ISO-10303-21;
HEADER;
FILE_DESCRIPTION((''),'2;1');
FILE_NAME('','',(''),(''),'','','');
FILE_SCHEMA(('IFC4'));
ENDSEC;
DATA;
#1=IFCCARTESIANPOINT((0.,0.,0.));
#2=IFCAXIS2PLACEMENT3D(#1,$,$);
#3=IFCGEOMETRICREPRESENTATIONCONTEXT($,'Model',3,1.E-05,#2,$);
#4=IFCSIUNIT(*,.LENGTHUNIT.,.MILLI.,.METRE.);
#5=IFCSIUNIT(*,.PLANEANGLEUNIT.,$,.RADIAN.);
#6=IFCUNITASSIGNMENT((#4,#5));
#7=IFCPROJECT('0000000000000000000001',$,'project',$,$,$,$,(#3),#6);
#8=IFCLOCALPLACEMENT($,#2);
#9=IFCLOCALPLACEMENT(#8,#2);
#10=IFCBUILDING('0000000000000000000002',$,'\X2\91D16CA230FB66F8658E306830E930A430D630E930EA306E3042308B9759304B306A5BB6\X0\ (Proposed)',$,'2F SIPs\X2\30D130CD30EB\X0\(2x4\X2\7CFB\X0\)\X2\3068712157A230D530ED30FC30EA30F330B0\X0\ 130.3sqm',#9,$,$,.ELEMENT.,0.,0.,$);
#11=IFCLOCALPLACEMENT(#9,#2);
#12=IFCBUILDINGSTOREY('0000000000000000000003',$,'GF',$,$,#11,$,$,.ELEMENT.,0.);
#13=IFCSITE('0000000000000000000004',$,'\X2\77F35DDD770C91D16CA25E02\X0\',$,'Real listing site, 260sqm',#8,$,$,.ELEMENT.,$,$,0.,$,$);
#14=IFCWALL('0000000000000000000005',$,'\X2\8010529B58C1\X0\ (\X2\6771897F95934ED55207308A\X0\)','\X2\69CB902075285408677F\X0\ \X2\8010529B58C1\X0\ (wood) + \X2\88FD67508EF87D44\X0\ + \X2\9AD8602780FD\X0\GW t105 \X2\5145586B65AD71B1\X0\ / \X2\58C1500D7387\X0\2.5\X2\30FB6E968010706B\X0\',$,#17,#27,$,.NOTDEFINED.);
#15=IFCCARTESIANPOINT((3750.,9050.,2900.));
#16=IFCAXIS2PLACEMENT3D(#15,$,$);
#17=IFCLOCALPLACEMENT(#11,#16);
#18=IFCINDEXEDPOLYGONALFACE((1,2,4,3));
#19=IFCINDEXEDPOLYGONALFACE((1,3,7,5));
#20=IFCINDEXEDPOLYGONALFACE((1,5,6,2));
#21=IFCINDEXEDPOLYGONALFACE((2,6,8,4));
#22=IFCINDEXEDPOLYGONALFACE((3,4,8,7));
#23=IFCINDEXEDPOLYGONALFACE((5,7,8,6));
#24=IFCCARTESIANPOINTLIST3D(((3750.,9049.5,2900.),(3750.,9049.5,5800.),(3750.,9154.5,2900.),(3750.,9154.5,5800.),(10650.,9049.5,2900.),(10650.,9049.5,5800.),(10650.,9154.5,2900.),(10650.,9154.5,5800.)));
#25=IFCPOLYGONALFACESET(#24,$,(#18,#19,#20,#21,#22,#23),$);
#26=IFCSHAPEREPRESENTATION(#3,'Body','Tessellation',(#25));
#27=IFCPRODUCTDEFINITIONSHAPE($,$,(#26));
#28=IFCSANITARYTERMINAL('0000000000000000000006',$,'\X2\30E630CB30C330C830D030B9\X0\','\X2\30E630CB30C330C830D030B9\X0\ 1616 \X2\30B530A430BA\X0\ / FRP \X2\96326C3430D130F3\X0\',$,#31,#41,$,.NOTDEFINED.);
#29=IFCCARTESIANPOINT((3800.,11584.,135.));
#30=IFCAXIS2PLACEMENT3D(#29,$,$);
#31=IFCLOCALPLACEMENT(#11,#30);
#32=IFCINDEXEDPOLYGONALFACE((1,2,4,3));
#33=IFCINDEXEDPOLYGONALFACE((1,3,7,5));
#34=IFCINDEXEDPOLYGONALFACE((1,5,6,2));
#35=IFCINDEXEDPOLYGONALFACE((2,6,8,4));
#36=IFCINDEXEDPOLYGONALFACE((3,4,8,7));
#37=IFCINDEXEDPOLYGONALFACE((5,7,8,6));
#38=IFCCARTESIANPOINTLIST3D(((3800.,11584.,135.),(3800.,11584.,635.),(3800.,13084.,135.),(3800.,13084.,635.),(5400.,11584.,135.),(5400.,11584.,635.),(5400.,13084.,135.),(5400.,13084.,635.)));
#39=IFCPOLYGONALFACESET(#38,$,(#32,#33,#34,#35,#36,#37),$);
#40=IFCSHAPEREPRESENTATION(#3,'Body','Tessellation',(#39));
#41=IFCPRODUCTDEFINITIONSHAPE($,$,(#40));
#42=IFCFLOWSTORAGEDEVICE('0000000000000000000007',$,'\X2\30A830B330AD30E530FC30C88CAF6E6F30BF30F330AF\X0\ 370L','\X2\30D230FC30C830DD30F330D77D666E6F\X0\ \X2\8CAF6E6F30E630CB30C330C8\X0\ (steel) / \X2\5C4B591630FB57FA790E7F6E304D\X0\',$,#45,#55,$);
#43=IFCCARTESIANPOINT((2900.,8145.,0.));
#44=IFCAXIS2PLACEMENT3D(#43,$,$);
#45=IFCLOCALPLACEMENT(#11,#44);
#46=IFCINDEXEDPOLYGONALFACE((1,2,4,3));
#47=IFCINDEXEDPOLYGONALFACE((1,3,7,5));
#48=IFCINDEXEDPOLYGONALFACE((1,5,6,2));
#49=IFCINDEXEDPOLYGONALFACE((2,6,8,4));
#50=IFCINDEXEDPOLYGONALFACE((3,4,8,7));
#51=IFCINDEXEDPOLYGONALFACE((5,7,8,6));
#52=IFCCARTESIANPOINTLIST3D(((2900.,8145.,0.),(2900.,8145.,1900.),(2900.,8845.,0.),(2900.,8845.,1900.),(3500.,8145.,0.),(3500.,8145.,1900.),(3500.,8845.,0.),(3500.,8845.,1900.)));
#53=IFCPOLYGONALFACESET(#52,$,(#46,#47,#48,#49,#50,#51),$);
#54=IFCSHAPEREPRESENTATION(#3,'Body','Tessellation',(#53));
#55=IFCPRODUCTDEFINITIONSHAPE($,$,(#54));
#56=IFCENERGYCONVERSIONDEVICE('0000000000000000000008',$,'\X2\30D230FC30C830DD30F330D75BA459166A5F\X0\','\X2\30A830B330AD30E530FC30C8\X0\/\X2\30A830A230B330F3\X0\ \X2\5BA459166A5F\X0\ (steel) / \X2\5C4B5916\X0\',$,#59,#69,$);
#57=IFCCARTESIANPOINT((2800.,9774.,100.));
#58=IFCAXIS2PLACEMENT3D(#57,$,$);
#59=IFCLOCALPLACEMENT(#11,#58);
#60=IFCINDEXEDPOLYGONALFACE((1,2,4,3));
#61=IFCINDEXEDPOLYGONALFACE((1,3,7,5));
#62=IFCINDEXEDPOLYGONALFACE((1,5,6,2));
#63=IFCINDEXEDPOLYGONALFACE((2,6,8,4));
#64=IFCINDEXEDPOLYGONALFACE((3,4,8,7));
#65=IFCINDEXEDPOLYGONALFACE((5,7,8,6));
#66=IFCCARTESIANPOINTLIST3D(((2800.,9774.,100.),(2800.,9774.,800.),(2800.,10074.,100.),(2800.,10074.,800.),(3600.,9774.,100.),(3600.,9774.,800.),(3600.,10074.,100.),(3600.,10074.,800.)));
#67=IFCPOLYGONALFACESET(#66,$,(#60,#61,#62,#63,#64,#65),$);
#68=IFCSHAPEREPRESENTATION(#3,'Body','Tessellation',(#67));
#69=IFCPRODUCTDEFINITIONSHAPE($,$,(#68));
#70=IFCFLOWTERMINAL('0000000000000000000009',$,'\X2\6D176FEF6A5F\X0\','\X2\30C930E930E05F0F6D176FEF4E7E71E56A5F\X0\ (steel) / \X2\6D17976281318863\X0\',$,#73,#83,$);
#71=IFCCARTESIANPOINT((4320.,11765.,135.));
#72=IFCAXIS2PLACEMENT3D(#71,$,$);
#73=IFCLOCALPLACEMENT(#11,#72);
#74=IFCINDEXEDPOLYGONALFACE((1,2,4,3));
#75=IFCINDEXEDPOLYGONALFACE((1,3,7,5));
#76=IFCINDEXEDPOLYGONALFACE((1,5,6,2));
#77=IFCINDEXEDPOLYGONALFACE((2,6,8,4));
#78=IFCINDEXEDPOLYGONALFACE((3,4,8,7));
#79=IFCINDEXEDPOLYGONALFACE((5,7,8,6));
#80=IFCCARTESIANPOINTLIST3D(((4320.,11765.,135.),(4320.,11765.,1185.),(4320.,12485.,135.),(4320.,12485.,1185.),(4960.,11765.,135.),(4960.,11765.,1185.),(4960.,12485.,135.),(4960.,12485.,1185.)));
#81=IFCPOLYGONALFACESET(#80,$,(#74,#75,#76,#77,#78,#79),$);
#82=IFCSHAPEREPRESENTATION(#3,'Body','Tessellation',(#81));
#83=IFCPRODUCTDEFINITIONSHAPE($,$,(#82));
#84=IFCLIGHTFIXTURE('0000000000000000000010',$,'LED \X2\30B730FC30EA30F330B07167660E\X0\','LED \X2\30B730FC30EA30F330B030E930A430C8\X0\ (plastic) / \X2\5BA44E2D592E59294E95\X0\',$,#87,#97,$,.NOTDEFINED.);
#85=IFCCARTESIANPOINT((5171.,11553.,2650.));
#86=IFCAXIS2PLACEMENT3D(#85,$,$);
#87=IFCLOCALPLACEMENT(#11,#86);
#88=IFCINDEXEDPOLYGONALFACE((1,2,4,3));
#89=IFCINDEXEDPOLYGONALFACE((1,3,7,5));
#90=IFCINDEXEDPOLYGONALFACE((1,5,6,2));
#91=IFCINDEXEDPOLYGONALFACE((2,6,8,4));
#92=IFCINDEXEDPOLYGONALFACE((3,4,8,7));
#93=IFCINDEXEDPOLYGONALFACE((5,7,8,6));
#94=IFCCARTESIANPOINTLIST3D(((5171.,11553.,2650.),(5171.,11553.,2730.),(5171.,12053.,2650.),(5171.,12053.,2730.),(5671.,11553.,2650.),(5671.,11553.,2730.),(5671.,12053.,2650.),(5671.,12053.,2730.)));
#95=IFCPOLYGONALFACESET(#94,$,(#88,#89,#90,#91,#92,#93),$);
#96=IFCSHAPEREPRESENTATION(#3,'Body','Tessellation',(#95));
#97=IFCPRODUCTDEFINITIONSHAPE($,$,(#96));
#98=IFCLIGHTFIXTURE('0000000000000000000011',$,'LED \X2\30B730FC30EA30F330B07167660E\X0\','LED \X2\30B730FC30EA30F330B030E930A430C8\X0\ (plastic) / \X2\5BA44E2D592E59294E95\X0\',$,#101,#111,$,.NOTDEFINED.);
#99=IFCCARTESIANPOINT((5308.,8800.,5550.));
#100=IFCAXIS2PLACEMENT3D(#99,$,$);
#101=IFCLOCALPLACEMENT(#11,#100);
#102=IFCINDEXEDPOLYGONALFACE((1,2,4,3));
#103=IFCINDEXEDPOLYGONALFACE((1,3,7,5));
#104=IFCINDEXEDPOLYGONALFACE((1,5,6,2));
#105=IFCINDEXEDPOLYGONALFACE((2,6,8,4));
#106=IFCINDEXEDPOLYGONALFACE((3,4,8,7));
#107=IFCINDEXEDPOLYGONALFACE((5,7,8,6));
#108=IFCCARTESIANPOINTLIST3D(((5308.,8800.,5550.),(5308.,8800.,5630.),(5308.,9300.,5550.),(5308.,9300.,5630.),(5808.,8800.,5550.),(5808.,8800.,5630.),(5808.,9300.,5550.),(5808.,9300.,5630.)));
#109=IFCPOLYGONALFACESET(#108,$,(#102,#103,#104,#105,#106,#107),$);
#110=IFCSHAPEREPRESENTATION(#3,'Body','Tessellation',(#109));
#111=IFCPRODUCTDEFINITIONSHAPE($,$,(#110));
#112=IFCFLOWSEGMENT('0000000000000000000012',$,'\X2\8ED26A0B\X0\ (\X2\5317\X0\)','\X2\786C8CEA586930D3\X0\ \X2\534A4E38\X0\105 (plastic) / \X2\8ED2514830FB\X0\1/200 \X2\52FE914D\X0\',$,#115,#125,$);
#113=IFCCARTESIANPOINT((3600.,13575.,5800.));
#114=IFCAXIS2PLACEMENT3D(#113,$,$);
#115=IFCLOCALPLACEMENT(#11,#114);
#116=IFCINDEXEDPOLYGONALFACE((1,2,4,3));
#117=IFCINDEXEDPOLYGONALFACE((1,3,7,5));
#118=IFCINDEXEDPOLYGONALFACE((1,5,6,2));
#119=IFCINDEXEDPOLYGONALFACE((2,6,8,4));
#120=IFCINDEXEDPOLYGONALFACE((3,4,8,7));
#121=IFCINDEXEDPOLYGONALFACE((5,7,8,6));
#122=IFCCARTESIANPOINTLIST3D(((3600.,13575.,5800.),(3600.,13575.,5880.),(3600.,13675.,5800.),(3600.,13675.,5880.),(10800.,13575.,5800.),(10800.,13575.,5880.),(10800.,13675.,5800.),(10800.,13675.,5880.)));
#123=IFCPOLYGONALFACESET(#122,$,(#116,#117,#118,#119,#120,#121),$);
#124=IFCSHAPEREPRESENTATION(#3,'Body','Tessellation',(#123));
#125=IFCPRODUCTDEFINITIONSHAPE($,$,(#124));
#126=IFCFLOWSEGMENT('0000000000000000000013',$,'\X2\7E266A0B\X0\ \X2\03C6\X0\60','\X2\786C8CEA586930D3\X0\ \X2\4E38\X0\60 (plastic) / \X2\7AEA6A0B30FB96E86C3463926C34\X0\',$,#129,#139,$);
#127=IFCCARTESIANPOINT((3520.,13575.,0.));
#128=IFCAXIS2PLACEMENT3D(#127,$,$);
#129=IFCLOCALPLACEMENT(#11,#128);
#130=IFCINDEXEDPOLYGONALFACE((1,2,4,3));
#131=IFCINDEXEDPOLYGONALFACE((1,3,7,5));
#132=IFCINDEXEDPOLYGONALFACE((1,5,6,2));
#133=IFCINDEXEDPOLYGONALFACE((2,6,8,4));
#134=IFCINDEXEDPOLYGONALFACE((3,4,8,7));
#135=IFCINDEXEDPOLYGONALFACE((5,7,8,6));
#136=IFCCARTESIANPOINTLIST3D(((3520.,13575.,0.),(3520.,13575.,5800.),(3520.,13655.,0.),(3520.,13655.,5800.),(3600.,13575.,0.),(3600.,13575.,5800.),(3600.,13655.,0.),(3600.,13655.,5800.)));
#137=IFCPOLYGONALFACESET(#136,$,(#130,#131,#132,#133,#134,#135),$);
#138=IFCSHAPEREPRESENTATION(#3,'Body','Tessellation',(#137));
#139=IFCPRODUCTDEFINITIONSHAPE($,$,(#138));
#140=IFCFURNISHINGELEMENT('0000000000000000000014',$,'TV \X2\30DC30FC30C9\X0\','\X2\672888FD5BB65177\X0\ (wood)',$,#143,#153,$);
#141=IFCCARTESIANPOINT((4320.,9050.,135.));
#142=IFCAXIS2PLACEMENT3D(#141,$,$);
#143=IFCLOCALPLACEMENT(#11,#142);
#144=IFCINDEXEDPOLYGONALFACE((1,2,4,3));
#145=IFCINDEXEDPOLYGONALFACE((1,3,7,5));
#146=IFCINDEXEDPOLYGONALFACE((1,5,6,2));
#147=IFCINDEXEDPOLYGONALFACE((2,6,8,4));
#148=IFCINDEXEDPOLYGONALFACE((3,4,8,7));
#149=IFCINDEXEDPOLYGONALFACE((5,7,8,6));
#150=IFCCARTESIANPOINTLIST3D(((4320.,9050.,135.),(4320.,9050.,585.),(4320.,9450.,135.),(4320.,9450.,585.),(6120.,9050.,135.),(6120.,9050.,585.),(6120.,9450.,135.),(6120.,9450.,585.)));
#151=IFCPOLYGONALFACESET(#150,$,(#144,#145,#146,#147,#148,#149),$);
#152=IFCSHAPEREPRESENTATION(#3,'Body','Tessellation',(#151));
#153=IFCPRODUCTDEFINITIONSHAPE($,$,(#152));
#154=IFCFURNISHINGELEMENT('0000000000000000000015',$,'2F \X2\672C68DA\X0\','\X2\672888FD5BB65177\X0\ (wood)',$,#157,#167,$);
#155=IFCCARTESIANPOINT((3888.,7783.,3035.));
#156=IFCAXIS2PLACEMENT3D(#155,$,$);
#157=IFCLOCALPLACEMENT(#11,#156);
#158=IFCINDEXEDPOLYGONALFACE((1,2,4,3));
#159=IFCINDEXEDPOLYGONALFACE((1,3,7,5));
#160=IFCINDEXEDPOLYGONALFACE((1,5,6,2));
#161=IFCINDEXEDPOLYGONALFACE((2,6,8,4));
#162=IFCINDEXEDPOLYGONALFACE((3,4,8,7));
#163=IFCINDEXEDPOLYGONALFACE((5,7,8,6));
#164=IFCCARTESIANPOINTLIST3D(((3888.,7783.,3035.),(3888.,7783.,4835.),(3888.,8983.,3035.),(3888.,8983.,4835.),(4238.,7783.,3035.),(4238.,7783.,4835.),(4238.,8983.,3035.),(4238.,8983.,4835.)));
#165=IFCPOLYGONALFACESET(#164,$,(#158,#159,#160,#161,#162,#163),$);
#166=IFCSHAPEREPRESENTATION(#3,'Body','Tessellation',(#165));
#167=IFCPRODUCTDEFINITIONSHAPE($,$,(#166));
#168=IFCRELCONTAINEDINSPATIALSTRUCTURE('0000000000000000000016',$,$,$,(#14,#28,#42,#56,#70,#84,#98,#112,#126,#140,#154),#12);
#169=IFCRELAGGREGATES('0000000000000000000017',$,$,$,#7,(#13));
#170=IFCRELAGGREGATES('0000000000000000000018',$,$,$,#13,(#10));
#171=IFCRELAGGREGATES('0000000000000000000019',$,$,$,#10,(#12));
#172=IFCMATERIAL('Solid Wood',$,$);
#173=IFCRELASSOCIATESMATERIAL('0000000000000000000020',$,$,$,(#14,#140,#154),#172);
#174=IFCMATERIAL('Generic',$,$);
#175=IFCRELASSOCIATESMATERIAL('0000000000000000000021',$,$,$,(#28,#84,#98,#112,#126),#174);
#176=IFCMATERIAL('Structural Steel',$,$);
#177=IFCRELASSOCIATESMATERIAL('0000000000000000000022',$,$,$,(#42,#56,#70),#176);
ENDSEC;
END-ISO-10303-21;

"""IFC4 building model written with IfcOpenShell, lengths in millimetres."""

from ifc_helpers import new_model, si_unit, frame, frame_2d, origin, place, context, project, spatial, rectangle, extrude, material, element, save


model = new_model("IFC4")

# Units and contexts
model_context = context("Model", 3, precision=1e-05, world=origin())
ifc_project = project(units=[si_unit("LENGTHUNIT", "METRE", prefix="MILLI"), si_unit("PLANEANGLEUNIT", "RADIAN")], contexts=[model_context])

# Site, building, storey
site_placement = place(None, origin())
site = spatial("IfcSite", under=ifc_project, at=site_placement, Name="石川県金沢市", ObjectType="Real listing site, 260sqm", CompositionType="ELEMENT", RefElevation=0.0)
building_placement = place(site_placement, origin())
building = spatial("IfcBuilding", under=site, at=building_placement, Name="金沢・書斎とライブラリのある静かな家 (Proposed)", ObjectType="2F SIPsパネル(2x4系)と無垢フローリング 130.3sqm", CompositionType="ELEMENT", ElevationOfRefHeight=0.0, ElevationOfTerrain=0.0)
storey_placement = place(building_placement, origin())
storey = spatial("IfcBuildingStorey", under=building, at=storey_placement, Name="GF", CompositionType="ELEMENT", Elevation=0.0)

# Shared definitions
ifc_material_1 = material(Name="Solid Wood")

# Wall
wall_1_placement = place(storey_placement, frame((3750.0, 9050.0, 2900.0)))
element("IfcWall", 1, at=wall_1_placement, inside=storey, material=ifc_material_1, Name="耐力壁 (東西間仕切り)", Description="構造用合板 耐力壁 (wood) + 製材軸組 + 高性能GW t105 充填断熱 / 壁倍率2.5・準耐火", PredefinedType="NOTDEFINED", context=model_context, shape_type="SweptSolid", body=[
    extrude(rectangle(XDim=6900.0, YDim=105.0, at=frame_2d((3450.0, 52.0))), frame((3750.0, 9050.0, 2900.0)), (0.0, 0.0, 1.0), 2900.0),
])

# Sanitary terminal
ifc_material_2 = material(Name="Generic")
sanitary_terminal_placement = place(storey_placement, frame((3800.0, 11584.0, 135.0)))
element("IfcSanitaryTerminal", 2, at=sanitary_terminal_placement, inside=storey, material=ifc_material_2, Name="ユニットバス", Description="ユニットバス 1616 サイズ / FRP 防水パン", PredefinedType="NOTDEFINED", context=model_context, shape_type="SweptSolid", body=[
    extrude(rectangle(XDim=1600.0, YDim=1500.0, at=frame_2d((800.0, 750.0))), frame((3800.0, 11584.0, 135.0)), (0.0, 0.0, 1.0), 500.0),
])

# Flow storage device
ifc_material_3 = material(Name="Structural Steel")
flow_storage_device_placement = place(storey_placement, frame((2900.0, 8145.0, 0.0)))
element("IfcFlowStorageDevice", 3, at=flow_storage_device_placement, inside=storey, material=ifc_material_3, Name="エコキュート貯湯タンク 370L", Description="ヒートポンプ給湯 貯湯ユニット (steel) / 屋外・基礎置き", context=model_context, shape_type="SweptSolid", body=[
    extrude(rectangle(XDim=600.0, YDim=700.0, at=frame_2d((300.0, 350.0))), frame((2900.0, 8145.0, 0.0)), (0.0, 0.0, 1.0), 1900.0),
])

# Energy conversion device
energy_conversion_device_placement = place(storey_placement, frame((2800.0, 9774.0, 100.0)))
element("IfcEnergyConversionDevice", 4, at=energy_conversion_device_placement, inside=storey, material=ifc_material_3, Name="ヒートポンプ室外機", Description="エコキュート/エアコン 室外機 (steel) / 屋外", context=model_context, shape_type="SweptSolid", body=[
    extrude(rectangle(XDim=800.0, YDim=300.0, at=frame_2d((400.0, 150.0))), frame((2800.0, 9774.0, 100.0)), (0.0, 0.0, 1.0), 700.0),
])

# Flow terminal
flow_terminal_placement = place(storey_placement, frame((4320.0, 11765.0, 135.0)))
element("IfcFlowTerminal", 5, at=flow_terminal_placement, inside=storey, material=ifc_material_3, Name="洗濯機", Description="ドラム式洗濯乾燥機 (steel) / 洗面脱衣", context=model_context, shape_type="SweptSolid", body=[
    extrude(rectangle(XDim=640.0, YDim=720.0, at=frame_2d((320.0, 360.0))), frame((4320.0, 11765.0, 135.0)), (0.0, 0.0, 1.0), 1050.0),
])

# Light fixtures
light_fixture_1_placement = place(storey_placement, frame((5171.0, 11553.0, 2650.0)))
element("IfcLightFixture", 6, at=light_fixture_1_placement, inside=storey, material=ifc_material_2, Name="LED シーリング照明", Description="LED シーリングライト (plastic) / 室中央天井", PredefinedType="NOTDEFINED", context=model_context, shape_type="SweptSolid", body=[
    extrude(rectangle(XDim=500.0, YDim=500.0, at=frame_2d((250.0, 250.0))), frame((5171.0, 11553.0, 2650.0)), (0.0, 0.0, 1.0), 80.0),
])
light_fixture_2_placement = place(storey_placement, frame((5308.0, 8800.0, 5550.0)))
element("IfcLightFixture", 7, at=light_fixture_2_placement, inside=storey, material=ifc_material_2, Name="LED シーリング照明", Description="LED シーリングライト (plastic) / 室中央天井", PredefinedType="NOTDEFINED", context=model_context, shape_type="SweptSolid", body=[
    extrude(rectangle(XDim=500.0, YDim=500.0, at=frame_2d((250.0, 250.0))), frame((5308.0, 8800.0, 5550.0)), (0.0, 0.0, 1.0), 80.0),
])

# Flow segments
flow_segment_1_placement = place(storey_placement, frame((3600.0, 13575.0, 5800.0)))
element("IfcFlowSegment", 8, at=flow_segment_1_placement, inside=storey, material=ifc_material_2, Name="軒樋 (北)", Description="硬質塩ビ 半丸105 (plastic) / 軒先・1/200 勾配", context=model_context, shape_type="SweptSolid", body=[
    extrude(rectangle(XDim=7200.0, YDim=100.0, at=frame_2d((3600.0, 50.0))), frame((3600.0, 13575.0, 5800.0)), (0.0, 0.0, 1.0), 80.0),
])
flow_segment_2_placement = place(storey_placement, frame((3520.0, 13575.0, 0.0)))
element("IfcFlowSegment", 9, at=flow_segment_2_placement, inside=storey, material=ifc_material_2, Name="縦樋 φ60", Description="硬質塩ビ 丸60 (plastic) / 竪樋・雨水排水", context=model_context, shape_type="SweptSolid", body=[
    extrude(rectangle(XDim=80.0, YDim=80.0, at=frame_2d((40.0, 40.0))), frame((3520.0, 13575.0, 0.0)), (0.0, 0.0, 1.0), 5800.0),
])

# Furnishing elements
furnishing_1_placement = place(storey_placement, frame((4320.0, 9050.0, 135.0)))
element("IfcFurnishingElement", 10, at=furnishing_1_placement, inside=storey, material=ifc_material_1, Name="TV ボード", Description="木製家具 (wood)", context=model_context, shape_type="SweptSolid", body=[
    extrude(rectangle(XDim=1800.0, YDim=400.0, at=frame_2d((900.0, 200.0))), frame((4320.0, 9050.0, 135.0)), (0.0, 0.0, 1.0), 450.0),
])
furnishing_2_placement = place(storey_placement, frame((3888.0, 7783.0, 3035.0)))
element("IfcFurnishingElement", 11, at=furnishing_2_placement, inside=storey, material=ifc_material_1, Name="2F 本棚", Description="木製家具 (wood)", context=model_context, shape_type="SweptSolid", body=[
    extrude(rectangle(XDim=350.0, YDim=1200.0, at=frame_2d((175.0, 600.0))), frame((3888.0, 7783.0, 3035.0)), (0.0, 0.0, 1.0), 1800.0),
])

save(model, "model.ifc")
